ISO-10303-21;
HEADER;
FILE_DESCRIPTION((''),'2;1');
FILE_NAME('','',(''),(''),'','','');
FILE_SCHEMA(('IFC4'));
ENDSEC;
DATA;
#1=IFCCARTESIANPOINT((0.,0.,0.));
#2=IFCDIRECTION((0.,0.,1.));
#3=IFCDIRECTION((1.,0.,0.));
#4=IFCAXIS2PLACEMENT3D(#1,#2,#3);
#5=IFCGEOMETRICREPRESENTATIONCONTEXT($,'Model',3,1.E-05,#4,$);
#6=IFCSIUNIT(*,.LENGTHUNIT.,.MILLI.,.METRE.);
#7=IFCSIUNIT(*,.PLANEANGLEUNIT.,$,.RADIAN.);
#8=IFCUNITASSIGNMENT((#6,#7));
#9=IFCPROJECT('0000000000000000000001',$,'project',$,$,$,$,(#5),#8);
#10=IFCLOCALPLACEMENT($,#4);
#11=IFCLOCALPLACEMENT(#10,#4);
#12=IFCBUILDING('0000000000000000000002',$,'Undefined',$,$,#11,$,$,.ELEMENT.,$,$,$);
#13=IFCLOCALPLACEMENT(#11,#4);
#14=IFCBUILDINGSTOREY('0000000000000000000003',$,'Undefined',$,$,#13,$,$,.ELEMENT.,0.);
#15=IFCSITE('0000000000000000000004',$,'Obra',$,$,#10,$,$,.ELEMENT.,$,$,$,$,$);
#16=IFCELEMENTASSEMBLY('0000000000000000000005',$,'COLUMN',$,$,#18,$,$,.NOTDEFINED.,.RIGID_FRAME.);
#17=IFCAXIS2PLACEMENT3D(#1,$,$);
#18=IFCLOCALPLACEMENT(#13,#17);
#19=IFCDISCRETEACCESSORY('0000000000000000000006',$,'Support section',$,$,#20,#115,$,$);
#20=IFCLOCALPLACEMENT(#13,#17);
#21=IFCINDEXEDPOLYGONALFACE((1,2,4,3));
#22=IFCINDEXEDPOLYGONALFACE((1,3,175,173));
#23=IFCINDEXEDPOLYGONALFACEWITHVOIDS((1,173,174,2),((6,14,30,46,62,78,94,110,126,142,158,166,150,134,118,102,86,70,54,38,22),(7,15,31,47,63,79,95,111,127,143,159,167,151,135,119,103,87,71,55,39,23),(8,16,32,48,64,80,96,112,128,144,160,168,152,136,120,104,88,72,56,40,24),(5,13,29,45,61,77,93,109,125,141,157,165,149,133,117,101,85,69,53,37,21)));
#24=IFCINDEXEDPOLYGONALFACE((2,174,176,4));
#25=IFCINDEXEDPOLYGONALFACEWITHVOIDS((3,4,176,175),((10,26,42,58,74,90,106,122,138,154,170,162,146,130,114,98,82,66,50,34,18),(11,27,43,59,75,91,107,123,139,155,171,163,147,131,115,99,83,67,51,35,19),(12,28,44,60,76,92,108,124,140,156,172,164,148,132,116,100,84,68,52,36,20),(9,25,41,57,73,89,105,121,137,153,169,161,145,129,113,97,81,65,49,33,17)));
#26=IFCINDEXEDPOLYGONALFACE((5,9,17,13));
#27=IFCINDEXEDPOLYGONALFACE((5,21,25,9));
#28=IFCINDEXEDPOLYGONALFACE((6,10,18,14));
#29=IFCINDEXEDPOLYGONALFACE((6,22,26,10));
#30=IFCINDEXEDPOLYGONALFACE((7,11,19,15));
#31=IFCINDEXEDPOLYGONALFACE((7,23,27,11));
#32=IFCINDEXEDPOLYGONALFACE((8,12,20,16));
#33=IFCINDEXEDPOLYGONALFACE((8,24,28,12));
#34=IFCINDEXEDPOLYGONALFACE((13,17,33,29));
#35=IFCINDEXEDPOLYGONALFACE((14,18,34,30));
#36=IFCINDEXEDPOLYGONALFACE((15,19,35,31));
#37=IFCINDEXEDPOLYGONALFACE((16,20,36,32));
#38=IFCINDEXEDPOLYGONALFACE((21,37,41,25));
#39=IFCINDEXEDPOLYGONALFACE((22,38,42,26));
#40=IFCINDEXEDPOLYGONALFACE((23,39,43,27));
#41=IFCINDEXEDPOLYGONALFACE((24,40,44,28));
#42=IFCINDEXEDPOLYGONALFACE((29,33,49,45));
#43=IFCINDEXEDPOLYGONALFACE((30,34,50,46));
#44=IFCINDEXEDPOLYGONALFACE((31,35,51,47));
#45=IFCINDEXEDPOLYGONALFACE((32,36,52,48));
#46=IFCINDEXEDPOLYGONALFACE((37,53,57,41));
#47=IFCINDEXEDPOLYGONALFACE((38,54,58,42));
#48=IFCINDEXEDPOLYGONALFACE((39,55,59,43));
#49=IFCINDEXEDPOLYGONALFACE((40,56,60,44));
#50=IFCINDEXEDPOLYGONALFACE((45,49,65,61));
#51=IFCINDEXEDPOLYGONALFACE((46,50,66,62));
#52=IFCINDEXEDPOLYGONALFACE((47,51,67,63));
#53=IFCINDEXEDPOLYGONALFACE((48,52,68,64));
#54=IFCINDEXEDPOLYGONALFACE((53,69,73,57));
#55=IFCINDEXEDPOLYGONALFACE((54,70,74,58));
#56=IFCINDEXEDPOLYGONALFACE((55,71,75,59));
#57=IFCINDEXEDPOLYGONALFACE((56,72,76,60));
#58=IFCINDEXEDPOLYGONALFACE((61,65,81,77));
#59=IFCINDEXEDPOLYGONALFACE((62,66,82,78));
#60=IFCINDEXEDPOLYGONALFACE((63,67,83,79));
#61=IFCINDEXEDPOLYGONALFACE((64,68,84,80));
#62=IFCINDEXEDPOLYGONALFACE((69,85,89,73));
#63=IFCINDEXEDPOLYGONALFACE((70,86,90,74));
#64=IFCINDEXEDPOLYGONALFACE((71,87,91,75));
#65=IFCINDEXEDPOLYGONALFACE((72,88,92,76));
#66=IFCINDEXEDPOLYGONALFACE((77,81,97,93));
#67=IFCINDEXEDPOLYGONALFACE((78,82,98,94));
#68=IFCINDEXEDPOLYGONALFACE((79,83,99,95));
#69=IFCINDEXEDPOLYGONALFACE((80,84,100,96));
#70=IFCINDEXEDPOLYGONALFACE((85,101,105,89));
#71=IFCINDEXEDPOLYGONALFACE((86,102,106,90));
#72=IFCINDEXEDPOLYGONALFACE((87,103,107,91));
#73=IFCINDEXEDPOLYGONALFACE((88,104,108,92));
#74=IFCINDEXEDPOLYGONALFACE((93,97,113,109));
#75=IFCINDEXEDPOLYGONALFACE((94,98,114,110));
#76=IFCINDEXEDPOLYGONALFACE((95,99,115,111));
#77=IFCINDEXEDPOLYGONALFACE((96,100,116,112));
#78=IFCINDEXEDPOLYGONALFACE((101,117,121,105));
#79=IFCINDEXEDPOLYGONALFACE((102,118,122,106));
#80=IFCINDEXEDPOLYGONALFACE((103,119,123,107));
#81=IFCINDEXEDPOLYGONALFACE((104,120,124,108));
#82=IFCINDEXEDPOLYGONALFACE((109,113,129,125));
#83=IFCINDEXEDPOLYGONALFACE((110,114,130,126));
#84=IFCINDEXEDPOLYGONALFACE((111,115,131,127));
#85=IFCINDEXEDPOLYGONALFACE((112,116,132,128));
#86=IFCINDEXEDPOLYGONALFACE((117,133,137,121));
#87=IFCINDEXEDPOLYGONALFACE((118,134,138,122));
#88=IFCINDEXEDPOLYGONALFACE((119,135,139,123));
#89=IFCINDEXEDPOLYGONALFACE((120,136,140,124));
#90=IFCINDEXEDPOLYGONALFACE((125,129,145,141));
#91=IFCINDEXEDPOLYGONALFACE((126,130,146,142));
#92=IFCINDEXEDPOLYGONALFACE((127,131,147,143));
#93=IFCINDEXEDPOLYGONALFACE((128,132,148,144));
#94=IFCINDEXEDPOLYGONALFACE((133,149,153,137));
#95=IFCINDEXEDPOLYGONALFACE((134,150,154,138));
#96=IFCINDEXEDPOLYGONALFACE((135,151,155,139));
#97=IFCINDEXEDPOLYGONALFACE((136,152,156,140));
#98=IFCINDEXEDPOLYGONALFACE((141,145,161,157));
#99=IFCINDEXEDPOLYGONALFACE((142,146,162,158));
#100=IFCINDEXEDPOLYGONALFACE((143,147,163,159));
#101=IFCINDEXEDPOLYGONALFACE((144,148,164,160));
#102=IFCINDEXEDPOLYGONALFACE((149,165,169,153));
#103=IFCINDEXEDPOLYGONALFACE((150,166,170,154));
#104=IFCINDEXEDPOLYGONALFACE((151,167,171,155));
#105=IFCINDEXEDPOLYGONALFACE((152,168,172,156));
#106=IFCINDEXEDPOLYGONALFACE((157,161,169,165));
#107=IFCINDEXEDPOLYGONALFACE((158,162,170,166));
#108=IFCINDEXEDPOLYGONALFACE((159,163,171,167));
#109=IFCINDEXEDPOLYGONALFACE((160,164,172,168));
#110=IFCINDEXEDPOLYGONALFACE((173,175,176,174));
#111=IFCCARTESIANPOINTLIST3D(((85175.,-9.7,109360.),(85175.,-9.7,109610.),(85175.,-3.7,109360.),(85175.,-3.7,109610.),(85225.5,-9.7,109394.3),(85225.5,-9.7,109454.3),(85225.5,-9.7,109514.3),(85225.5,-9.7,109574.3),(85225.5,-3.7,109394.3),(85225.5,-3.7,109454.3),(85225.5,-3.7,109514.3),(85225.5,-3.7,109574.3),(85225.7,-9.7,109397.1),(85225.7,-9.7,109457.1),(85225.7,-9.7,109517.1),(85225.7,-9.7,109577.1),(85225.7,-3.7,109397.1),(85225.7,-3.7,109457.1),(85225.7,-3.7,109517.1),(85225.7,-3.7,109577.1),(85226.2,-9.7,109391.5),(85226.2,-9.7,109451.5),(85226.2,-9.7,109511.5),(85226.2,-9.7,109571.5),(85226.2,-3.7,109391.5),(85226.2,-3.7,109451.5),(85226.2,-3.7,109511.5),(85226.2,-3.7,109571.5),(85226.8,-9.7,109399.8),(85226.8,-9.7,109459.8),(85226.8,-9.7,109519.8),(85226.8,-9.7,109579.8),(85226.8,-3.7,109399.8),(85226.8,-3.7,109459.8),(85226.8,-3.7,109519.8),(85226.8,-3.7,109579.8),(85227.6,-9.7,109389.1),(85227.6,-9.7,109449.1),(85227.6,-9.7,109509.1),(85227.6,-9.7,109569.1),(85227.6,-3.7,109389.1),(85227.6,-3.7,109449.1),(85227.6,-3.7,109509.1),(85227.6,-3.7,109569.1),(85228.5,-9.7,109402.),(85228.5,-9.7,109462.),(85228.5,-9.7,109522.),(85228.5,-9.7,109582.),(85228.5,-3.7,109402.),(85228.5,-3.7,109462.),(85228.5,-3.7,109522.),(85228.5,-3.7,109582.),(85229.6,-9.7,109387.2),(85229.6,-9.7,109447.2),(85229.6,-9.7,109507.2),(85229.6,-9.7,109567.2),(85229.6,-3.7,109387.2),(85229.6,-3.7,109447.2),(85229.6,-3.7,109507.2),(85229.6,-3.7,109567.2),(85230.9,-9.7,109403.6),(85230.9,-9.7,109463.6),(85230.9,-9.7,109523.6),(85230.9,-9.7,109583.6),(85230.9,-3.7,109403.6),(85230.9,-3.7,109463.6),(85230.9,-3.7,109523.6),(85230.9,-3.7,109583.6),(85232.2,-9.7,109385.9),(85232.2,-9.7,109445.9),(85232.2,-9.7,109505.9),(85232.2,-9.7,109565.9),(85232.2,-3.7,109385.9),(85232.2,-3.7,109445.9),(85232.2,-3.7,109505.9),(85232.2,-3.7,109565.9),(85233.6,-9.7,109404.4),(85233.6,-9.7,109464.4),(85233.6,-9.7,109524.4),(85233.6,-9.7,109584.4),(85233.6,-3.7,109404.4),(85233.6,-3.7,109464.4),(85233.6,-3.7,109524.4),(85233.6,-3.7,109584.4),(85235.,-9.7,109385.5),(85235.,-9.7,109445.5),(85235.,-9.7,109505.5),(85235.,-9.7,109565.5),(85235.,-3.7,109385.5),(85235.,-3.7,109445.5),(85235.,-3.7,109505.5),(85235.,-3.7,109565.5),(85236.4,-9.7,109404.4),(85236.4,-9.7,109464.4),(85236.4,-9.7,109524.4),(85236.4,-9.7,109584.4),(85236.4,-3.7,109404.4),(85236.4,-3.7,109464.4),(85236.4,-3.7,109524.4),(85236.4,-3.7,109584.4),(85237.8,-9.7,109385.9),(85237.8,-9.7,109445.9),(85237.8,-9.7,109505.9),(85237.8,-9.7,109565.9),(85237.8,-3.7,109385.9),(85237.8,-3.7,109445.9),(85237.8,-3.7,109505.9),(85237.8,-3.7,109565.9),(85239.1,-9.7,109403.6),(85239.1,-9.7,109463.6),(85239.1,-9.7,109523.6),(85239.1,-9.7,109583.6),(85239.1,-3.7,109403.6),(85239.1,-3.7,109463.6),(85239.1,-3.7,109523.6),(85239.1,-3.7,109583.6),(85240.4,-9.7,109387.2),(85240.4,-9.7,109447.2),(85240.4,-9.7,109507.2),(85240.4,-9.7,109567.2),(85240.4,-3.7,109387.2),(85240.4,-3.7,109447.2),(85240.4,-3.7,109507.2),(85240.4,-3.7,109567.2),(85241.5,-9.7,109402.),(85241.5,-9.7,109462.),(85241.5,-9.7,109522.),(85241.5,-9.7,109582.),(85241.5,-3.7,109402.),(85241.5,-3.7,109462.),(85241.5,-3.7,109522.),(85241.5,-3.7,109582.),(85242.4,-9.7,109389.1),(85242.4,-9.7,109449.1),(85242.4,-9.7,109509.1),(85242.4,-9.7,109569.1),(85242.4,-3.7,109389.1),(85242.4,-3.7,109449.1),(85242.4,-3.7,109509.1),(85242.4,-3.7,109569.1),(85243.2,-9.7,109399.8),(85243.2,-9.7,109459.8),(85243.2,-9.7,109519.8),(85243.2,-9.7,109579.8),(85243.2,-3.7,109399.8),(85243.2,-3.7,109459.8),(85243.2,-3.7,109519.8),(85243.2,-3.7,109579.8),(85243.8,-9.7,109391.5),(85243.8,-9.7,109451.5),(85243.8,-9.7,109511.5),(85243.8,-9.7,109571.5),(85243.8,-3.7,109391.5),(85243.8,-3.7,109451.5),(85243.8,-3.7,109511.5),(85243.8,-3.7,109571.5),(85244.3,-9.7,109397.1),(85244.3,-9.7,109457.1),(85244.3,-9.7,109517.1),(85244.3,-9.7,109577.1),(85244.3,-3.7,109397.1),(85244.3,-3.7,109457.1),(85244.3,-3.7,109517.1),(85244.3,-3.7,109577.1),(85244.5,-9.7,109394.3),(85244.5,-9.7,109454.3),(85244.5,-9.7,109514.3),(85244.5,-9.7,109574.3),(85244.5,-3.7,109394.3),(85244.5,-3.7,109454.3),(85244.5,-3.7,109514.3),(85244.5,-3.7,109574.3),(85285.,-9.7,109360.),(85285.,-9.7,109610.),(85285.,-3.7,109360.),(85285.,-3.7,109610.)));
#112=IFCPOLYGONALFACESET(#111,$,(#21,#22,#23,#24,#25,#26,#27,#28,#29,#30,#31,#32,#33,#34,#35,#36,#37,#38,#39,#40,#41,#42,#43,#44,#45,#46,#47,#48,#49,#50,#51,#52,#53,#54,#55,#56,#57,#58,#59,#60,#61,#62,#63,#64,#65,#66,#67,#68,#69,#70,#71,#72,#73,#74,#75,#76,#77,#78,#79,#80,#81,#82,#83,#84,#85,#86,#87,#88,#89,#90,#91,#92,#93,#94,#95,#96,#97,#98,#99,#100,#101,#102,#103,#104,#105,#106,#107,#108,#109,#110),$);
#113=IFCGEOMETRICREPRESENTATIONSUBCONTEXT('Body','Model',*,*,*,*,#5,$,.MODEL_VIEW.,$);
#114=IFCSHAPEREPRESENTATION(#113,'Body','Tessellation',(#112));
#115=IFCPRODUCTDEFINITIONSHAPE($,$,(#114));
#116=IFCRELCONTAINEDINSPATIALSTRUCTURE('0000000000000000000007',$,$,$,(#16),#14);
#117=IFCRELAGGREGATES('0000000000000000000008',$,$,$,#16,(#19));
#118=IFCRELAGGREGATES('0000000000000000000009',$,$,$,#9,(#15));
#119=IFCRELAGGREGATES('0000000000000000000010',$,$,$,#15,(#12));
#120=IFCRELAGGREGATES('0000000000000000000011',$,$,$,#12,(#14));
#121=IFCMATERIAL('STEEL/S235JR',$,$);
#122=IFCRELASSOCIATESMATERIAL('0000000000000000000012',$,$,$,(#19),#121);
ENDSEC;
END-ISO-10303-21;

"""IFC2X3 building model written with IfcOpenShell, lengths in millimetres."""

from ifc_helpers import new_model, si_unit, frame, origin_with_axes, origin_2d_with_axis, place, context, subcontext, project, spatial, rectangle, circle, extrude, source, transform, mapped, material, element, aggregate, save


model = new_model("IFC2X3")

# Units and contexts
model_context = context("Model", 3, precision=1e-05, world=origin_with_axes())
body_context = subcontext(model_context, "Body", "Model", "MODEL_VIEW")
ifc_project = project(units=[si_unit("LENGTHUNIT", "METRE", prefix="MILLI"), si_unit("PLANEANGLEUNIT", "RADIAN")], contexts=[model_context])

# Site, building, storey
site_placement = place(None, origin_with_axes())
site = spatial("IfcSite", under=ifc_project, at=site_placement, Name="Obra", CompositionType="ELEMENT")
building_placement = place(site_placement, origin_with_axes())
building = spatial("IfcBuilding", under=site, at=building_placement, Name="Undefined", CompositionType="ELEMENT")
storey_placement = place(building_placement, origin_with_axes())
storey = spatial("IfcBuildingStorey", under=building, at=storey_placement, Name="Undefined", CompositionType="ELEMENT", Elevation=0.0)

# Element assembly
assembly_1_placement = place(storey_placement, origin_with_axes())
assembly_1 = element("IfcElementAssembly", 1, at=assembly_1_placement, inside=storey, Name="COLUMN", AssemblyPlace="NOTDEFINED", PredefinedType="RIGID_FRAME")
ifc_material_1 = material(Name="STEEL/S235JR")

# Discrete accessory, opening
shared_shape_1 = source(origin_with_axes(), body_context, "Body", "SweptSolid", [
    extrude(circle(Radius=9.5, at=origin_2d_with_axis()), frame((0.0, -9.8, 0.0), z_axis=(0.0, 1.0, 0.0), x_axis=(1.0, 0.0, 0.0)), (0.0, 0.0, 1.0), 6.2),
])
discrete_accessory_1_placement = place(assembly_1_placement, frame((85230.0, -6.7, 109360.0), z_axis=(0.0, 0.0, 1.0), x_axis=(-1.0, 0.0, 0.0)))
discrete_accessory_1 = element("IfcDiscreteAccessory", 2, at=discrete_accessory_1_placement, material=ifc_material_1, Name="Support section", context=body_context, shape_type="SweptSolid", body=[
    extrude(rectangle(XDim=6.0, YDim=110.0, at=origin_2d_with_axis()), frame((0.0, 0.0, 250.0), z_axis=(0.0, 0.0, -1.0), x_axis=(0.0, 1.0, 0.0)), (0.0, 0.0, 1.0), 250.0),
])
opening_1_placement = place(assembly_1_placement, frame((85185.0, 0.0, 109650.0), z_axis=(1.0, 0.0, 0.0), x_axis=(0.0, 0.0, -1.0)))
element("IfcOpeningElement", 3, at=opening_1_placement, cuts=discrete_accessory_1, ObjectType="Opening", context=body_context, shape_type="MappedRepresentation", body=[
    mapped(shared_shape_1, transform((75.0, 0.0, 50.0))),
    mapped(shared_shape_1, transform((135.0, 0.0, 50.0))),
    mapped(shared_shape_1, transform((195.0, 0.0, 50.0))),
    mapped(shared_shape_1, transform((255.0, 0.0, 50.0))),
])
aggregate(assembly_1, [discrete_accessory_1])

save(model, "model.ifc")
